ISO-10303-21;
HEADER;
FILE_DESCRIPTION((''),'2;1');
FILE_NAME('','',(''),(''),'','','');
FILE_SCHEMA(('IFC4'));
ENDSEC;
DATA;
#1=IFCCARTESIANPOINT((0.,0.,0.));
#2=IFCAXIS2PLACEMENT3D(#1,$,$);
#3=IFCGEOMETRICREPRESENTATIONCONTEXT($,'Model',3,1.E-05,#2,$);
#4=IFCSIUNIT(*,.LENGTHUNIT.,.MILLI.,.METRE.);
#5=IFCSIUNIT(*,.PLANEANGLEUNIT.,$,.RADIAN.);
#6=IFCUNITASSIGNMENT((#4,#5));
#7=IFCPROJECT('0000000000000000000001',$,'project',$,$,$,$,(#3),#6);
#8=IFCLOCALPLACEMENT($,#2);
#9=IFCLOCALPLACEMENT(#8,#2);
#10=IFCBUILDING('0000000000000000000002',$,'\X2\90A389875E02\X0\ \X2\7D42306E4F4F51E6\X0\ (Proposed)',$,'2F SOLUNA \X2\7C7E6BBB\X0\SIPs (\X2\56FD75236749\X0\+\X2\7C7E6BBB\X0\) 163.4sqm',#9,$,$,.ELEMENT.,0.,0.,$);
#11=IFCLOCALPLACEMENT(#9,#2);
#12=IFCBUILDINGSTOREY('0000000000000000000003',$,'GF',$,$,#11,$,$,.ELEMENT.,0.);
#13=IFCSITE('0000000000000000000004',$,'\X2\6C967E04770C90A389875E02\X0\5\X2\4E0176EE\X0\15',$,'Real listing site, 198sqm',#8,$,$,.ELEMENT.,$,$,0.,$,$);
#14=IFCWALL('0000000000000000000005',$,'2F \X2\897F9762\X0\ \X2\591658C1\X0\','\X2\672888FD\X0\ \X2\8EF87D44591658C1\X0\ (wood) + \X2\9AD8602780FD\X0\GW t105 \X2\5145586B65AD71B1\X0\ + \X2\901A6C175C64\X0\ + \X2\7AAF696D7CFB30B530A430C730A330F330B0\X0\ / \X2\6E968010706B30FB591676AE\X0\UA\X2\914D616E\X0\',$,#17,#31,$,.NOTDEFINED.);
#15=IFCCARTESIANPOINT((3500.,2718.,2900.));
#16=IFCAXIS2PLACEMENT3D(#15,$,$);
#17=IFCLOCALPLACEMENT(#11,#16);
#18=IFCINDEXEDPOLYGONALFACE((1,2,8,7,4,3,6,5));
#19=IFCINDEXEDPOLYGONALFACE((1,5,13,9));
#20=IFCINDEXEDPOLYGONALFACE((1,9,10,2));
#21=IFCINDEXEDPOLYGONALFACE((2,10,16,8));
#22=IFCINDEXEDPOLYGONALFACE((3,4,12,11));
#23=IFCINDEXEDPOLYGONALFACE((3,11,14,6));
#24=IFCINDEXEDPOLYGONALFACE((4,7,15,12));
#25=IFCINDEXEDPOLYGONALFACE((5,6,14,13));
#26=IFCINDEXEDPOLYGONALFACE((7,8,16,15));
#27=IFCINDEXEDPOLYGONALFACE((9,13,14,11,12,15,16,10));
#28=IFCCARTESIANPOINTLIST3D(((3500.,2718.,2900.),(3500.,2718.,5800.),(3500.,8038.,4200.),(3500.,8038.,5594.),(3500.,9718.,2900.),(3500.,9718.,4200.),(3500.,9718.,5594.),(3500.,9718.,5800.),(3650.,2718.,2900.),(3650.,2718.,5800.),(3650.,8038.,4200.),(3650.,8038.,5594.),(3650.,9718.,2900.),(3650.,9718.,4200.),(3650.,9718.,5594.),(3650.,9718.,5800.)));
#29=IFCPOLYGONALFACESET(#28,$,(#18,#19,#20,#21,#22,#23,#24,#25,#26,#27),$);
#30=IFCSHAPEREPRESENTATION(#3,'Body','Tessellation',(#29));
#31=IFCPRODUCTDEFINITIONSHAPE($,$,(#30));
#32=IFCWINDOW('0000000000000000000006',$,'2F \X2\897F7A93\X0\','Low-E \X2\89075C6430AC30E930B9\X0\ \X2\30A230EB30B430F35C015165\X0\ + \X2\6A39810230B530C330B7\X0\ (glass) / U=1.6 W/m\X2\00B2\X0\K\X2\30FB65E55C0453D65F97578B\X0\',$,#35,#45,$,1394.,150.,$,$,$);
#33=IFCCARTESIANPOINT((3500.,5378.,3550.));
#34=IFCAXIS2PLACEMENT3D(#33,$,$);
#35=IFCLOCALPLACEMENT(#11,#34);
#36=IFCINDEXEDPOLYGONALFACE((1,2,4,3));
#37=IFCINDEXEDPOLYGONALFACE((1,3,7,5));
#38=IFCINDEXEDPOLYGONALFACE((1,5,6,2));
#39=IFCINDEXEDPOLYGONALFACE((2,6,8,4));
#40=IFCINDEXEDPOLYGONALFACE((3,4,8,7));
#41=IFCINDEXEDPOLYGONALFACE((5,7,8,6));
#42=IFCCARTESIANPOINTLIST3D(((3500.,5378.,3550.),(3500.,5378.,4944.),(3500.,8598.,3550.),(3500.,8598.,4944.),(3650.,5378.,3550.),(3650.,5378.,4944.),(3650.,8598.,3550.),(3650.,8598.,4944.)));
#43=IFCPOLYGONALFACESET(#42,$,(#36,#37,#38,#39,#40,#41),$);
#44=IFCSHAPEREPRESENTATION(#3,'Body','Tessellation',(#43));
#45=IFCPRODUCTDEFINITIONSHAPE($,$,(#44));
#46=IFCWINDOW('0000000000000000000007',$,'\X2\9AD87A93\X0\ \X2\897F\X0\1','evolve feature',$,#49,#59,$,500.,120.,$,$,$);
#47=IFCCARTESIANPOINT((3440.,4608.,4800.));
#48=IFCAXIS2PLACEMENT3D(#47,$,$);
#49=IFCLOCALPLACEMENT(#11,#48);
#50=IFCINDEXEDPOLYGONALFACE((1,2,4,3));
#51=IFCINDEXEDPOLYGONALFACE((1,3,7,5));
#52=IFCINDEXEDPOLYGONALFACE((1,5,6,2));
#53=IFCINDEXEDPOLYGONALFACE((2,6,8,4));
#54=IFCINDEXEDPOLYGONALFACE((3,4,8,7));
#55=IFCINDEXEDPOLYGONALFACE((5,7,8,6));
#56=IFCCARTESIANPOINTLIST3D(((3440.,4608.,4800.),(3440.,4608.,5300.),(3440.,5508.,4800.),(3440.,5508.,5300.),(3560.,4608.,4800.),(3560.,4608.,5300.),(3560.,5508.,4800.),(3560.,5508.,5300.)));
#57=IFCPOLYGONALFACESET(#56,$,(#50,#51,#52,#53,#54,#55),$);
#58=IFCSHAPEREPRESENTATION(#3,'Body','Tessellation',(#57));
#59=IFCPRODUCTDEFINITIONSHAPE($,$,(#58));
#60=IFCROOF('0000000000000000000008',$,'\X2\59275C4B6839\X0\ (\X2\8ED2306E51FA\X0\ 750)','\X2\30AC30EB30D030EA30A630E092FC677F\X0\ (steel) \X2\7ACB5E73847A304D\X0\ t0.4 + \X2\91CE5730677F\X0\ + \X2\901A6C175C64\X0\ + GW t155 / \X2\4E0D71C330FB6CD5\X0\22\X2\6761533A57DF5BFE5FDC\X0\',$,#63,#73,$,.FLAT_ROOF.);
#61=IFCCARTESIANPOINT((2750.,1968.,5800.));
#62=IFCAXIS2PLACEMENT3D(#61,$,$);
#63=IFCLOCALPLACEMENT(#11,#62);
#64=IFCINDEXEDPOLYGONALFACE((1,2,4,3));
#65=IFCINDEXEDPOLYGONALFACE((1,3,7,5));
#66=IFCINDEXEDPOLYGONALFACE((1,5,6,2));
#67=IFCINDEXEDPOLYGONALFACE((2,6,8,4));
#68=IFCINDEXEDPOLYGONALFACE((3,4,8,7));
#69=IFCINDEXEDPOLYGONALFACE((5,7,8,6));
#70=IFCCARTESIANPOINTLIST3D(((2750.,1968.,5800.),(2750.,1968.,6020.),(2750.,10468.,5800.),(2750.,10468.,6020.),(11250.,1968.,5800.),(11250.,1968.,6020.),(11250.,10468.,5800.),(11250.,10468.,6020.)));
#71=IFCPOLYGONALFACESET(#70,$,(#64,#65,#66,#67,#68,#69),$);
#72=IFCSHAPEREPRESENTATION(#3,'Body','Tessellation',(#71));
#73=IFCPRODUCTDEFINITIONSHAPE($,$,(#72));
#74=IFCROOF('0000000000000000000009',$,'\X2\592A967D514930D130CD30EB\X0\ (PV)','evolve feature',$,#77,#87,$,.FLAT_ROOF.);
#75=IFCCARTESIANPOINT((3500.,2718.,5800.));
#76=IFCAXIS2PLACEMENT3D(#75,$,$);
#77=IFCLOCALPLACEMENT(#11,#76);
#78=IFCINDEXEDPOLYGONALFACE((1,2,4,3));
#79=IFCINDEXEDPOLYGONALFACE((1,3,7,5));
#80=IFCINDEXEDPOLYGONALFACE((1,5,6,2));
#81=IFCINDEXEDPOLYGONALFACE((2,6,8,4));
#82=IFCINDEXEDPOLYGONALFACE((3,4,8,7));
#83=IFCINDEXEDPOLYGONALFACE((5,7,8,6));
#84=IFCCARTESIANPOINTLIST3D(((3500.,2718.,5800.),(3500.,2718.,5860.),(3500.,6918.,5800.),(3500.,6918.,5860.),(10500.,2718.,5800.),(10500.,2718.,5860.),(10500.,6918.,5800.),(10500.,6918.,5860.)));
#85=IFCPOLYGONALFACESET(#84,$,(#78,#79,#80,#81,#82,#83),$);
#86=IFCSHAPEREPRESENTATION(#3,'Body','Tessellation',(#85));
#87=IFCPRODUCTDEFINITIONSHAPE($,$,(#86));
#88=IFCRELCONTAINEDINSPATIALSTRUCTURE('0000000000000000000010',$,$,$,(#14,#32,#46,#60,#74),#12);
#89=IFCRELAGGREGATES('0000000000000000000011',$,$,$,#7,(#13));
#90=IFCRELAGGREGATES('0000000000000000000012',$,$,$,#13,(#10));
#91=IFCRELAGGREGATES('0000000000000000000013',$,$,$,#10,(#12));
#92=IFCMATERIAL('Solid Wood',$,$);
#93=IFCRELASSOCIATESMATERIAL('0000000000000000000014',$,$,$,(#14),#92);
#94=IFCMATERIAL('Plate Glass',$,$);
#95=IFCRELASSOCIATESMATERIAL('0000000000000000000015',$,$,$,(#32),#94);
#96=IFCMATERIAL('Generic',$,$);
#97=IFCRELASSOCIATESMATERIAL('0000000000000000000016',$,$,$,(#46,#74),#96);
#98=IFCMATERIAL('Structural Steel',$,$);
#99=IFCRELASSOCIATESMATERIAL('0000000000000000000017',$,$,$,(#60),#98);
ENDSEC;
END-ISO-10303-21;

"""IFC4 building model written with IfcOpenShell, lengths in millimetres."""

from ifc_helpers import new_model, si_unit, frame, frame_2d, origin, place, context, project, spatial, rectangle, extrude, material, element, fill, save


model = new_model("IFC4")

# Units and contexts
model_context = context("Model", 3, precision=1e-05, world=origin())
ifc_project = project(units=[si_unit("LENGTHUNIT", "METRE", prefix="MILLI"), si_unit("PLANEANGLEUNIT", "RADIAN")], contexts=[model_context])

# Site, building, storey
site_placement = place(None, origin())
site = spatial("IfcSite", under=ifc_project, at=site_placement, Name="沖縄県那覇市5丁目15", ObjectType="Real listing site, 198sqm", CompositionType="ELEMENT", RefElevation=0.0)
building_placement = place(site_placement, origin())
building = spatial("IfcBuilding", under=site, at=building_placement, Name="那覇市 終の住処 (Proposed)", ObjectType="2F SOLUNA 籾殻SIPs (国産杉+籾殻) 163.4sqm", CompositionType="ELEMENT", ElevationOfRefHeight=0.0, ElevationOfTerrain=0.0)
storey_placement = place(building_placement, origin())
storey = spatial("IfcBuildingStorey", under=building, at=storey_placement, Name="GF", CompositionType="ELEMENT", Elevation=0.0)

# Shared definitions
ifc_material_1 = material(Name="Solid Wood")
ifc_material_2 = material(Name="Generic")

# Shared definitions
ifc_material_3 = material(Name="Plate Glass")

# Wall, openings, windows
wall_1_placement = place(storey_placement, frame((3500.0, 2718.0, 2900.0)))
wall_1 = element("IfcWall", 1, at=wall_1_placement, inside=storey, material=ifc_material_1, Name="2F 西面 外壁", Description="木製 軸組外壁 (wood) + 高性能GW t105 充填断熱 + 通気層 + 窯業系サイディング / 準耐火・外皮UA配慮", PredefinedType="NOTDEFINED", context=model_context, shape_type="SweptSolid", body=[
    extrude(rectangle(XDim=150.0, YDim=7000.0, at=frame_2d((75.0, 3500.0))), frame((3500.0, 2718.0, 2900.0)), (0.0, 0.0, 1.0), 2900.0),
])
opening_1_placement = place(storey_placement, frame((3500.0, 5378.0, 3550.0)))
opening_1 = element("IfcOpeningElement", 2, at=opening_1_placement, cuts=wall_1, PredefinedType="NOTDEFINED", context=model_context, shape_type="SweptSolid", body=[
    extrude(rectangle(XDim=150.0, YDim=3220.0, at=frame_2d((75.0, 1610.0))), frame((3500.0, 5378.0, 3550.0)), (0.0, 0.0, 1.0), 1394.0),
])
opening_2_placement = place(storey_placement, frame((3440.0, 4608.0, 4800.0)))
opening_2 = element("IfcOpeningElement", 3, at=opening_2_placement, cuts=wall_1, PredefinedType="NOTDEFINED", context=model_context, shape_type="SweptSolid", body=[
    extrude(rectangle(XDim=120.0, YDim=900.0, at=frame_2d((60.0, 450.0))), frame((3440.0, 4608.0, 4800.0)), (0.0, 0.0, 1.0), 500.0),
])
window_1_placement = place(storey_placement, frame((3500.0, 5378.0, 3550.0)))
window_1 = element("IfcWindow", 4, at=window_1_placement, inside=storey, material=ifc_material_3, Name="2F 西窓", Description="Low-E 複層ガラス アルゴン封入 + 樹脂サッシ (glass) / U=1.6 W/m²K・日射取得型", OverallHeight=1394.0, OverallWidth=150.0, context=model_context, shape_type="SweptSolid", body=[
    extrude(rectangle(XDim=150.0, YDim=3220.0, at=frame_2d((75.0, 1610.0))), frame((3500.0, 5378.0, 3550.0)), (0.0, 0.0, 1.0), 1394.0),
])
fill(opening_1, window_1)
window_2_placement = place(storey_placement, frame((3440.0, 4608.0, 4800.0)))
window_2 = element("IfcWindow", 5, at=window_2_placement, inside=storey, material=ifc_material_2, Name="高窓 西1", Description="evolve feature", OverallHeight=500.0, OverallWidth=120.0, context=model_context, shape_type="SweptSolid", body=[
    extrude(rectangle(XDim=120.0, YDim=900.0, at=frame_2d((60.0, 450.0))), frame((3440.0, 4608.0, 4800.0)), (0.0, 0.0, 1.0), 500.0),
])
fill(opening_2, window_2)

# Roofs
ifc_material_4 = material(Name="Structural Steel")
roof_1_placement = place(storey_placement, frame((2750.0, 1968.0, 5800.0)))
element("IfcRoof", 6, at=roof_1_placement, inside=storey, material=ifc_material_4, Name="大屋根 (軒の出 750)", Description="ガルバリウム鋼板 (steel) 立平葺き t0.4 + 野地板 + 通気層 + GW t155 / 不燃・法22条区域対応", PredefinedType="FLAT_ROOF", context=model_context, shape_type="SweptSolid", body=[
    extrude(rectangle(XDim=8500.0, YDim=8500.0, at=frame_2d((4250.0, 4250.0))), frame((2750.0, 1968.0, 5800.0)), (0.0, 0.0, 1.0), 220.0),
])
roof_2_placement = place(storey_placement, frame((3500.0, 2718.0, 5800.0)))
element("IfcRoof", 7, at=roof_2_placement, inside=storey, material=ifc_material_2, Name="太陽光パネル (PV)", Description="evolve feature", PredefinedType="FLAT_ROOF", context=model_context, shape_type="SweptSolid", body=[
    extrude(rectangle(XDim=7000.0, YDim=4200.0, at=frame_2d((3500.0, 2100.0))), frame((3500.0, 2718.0, 5800.0)), (0.0, 0.0, 1.0), 60.0),
])

save(model, "model.ifc")
